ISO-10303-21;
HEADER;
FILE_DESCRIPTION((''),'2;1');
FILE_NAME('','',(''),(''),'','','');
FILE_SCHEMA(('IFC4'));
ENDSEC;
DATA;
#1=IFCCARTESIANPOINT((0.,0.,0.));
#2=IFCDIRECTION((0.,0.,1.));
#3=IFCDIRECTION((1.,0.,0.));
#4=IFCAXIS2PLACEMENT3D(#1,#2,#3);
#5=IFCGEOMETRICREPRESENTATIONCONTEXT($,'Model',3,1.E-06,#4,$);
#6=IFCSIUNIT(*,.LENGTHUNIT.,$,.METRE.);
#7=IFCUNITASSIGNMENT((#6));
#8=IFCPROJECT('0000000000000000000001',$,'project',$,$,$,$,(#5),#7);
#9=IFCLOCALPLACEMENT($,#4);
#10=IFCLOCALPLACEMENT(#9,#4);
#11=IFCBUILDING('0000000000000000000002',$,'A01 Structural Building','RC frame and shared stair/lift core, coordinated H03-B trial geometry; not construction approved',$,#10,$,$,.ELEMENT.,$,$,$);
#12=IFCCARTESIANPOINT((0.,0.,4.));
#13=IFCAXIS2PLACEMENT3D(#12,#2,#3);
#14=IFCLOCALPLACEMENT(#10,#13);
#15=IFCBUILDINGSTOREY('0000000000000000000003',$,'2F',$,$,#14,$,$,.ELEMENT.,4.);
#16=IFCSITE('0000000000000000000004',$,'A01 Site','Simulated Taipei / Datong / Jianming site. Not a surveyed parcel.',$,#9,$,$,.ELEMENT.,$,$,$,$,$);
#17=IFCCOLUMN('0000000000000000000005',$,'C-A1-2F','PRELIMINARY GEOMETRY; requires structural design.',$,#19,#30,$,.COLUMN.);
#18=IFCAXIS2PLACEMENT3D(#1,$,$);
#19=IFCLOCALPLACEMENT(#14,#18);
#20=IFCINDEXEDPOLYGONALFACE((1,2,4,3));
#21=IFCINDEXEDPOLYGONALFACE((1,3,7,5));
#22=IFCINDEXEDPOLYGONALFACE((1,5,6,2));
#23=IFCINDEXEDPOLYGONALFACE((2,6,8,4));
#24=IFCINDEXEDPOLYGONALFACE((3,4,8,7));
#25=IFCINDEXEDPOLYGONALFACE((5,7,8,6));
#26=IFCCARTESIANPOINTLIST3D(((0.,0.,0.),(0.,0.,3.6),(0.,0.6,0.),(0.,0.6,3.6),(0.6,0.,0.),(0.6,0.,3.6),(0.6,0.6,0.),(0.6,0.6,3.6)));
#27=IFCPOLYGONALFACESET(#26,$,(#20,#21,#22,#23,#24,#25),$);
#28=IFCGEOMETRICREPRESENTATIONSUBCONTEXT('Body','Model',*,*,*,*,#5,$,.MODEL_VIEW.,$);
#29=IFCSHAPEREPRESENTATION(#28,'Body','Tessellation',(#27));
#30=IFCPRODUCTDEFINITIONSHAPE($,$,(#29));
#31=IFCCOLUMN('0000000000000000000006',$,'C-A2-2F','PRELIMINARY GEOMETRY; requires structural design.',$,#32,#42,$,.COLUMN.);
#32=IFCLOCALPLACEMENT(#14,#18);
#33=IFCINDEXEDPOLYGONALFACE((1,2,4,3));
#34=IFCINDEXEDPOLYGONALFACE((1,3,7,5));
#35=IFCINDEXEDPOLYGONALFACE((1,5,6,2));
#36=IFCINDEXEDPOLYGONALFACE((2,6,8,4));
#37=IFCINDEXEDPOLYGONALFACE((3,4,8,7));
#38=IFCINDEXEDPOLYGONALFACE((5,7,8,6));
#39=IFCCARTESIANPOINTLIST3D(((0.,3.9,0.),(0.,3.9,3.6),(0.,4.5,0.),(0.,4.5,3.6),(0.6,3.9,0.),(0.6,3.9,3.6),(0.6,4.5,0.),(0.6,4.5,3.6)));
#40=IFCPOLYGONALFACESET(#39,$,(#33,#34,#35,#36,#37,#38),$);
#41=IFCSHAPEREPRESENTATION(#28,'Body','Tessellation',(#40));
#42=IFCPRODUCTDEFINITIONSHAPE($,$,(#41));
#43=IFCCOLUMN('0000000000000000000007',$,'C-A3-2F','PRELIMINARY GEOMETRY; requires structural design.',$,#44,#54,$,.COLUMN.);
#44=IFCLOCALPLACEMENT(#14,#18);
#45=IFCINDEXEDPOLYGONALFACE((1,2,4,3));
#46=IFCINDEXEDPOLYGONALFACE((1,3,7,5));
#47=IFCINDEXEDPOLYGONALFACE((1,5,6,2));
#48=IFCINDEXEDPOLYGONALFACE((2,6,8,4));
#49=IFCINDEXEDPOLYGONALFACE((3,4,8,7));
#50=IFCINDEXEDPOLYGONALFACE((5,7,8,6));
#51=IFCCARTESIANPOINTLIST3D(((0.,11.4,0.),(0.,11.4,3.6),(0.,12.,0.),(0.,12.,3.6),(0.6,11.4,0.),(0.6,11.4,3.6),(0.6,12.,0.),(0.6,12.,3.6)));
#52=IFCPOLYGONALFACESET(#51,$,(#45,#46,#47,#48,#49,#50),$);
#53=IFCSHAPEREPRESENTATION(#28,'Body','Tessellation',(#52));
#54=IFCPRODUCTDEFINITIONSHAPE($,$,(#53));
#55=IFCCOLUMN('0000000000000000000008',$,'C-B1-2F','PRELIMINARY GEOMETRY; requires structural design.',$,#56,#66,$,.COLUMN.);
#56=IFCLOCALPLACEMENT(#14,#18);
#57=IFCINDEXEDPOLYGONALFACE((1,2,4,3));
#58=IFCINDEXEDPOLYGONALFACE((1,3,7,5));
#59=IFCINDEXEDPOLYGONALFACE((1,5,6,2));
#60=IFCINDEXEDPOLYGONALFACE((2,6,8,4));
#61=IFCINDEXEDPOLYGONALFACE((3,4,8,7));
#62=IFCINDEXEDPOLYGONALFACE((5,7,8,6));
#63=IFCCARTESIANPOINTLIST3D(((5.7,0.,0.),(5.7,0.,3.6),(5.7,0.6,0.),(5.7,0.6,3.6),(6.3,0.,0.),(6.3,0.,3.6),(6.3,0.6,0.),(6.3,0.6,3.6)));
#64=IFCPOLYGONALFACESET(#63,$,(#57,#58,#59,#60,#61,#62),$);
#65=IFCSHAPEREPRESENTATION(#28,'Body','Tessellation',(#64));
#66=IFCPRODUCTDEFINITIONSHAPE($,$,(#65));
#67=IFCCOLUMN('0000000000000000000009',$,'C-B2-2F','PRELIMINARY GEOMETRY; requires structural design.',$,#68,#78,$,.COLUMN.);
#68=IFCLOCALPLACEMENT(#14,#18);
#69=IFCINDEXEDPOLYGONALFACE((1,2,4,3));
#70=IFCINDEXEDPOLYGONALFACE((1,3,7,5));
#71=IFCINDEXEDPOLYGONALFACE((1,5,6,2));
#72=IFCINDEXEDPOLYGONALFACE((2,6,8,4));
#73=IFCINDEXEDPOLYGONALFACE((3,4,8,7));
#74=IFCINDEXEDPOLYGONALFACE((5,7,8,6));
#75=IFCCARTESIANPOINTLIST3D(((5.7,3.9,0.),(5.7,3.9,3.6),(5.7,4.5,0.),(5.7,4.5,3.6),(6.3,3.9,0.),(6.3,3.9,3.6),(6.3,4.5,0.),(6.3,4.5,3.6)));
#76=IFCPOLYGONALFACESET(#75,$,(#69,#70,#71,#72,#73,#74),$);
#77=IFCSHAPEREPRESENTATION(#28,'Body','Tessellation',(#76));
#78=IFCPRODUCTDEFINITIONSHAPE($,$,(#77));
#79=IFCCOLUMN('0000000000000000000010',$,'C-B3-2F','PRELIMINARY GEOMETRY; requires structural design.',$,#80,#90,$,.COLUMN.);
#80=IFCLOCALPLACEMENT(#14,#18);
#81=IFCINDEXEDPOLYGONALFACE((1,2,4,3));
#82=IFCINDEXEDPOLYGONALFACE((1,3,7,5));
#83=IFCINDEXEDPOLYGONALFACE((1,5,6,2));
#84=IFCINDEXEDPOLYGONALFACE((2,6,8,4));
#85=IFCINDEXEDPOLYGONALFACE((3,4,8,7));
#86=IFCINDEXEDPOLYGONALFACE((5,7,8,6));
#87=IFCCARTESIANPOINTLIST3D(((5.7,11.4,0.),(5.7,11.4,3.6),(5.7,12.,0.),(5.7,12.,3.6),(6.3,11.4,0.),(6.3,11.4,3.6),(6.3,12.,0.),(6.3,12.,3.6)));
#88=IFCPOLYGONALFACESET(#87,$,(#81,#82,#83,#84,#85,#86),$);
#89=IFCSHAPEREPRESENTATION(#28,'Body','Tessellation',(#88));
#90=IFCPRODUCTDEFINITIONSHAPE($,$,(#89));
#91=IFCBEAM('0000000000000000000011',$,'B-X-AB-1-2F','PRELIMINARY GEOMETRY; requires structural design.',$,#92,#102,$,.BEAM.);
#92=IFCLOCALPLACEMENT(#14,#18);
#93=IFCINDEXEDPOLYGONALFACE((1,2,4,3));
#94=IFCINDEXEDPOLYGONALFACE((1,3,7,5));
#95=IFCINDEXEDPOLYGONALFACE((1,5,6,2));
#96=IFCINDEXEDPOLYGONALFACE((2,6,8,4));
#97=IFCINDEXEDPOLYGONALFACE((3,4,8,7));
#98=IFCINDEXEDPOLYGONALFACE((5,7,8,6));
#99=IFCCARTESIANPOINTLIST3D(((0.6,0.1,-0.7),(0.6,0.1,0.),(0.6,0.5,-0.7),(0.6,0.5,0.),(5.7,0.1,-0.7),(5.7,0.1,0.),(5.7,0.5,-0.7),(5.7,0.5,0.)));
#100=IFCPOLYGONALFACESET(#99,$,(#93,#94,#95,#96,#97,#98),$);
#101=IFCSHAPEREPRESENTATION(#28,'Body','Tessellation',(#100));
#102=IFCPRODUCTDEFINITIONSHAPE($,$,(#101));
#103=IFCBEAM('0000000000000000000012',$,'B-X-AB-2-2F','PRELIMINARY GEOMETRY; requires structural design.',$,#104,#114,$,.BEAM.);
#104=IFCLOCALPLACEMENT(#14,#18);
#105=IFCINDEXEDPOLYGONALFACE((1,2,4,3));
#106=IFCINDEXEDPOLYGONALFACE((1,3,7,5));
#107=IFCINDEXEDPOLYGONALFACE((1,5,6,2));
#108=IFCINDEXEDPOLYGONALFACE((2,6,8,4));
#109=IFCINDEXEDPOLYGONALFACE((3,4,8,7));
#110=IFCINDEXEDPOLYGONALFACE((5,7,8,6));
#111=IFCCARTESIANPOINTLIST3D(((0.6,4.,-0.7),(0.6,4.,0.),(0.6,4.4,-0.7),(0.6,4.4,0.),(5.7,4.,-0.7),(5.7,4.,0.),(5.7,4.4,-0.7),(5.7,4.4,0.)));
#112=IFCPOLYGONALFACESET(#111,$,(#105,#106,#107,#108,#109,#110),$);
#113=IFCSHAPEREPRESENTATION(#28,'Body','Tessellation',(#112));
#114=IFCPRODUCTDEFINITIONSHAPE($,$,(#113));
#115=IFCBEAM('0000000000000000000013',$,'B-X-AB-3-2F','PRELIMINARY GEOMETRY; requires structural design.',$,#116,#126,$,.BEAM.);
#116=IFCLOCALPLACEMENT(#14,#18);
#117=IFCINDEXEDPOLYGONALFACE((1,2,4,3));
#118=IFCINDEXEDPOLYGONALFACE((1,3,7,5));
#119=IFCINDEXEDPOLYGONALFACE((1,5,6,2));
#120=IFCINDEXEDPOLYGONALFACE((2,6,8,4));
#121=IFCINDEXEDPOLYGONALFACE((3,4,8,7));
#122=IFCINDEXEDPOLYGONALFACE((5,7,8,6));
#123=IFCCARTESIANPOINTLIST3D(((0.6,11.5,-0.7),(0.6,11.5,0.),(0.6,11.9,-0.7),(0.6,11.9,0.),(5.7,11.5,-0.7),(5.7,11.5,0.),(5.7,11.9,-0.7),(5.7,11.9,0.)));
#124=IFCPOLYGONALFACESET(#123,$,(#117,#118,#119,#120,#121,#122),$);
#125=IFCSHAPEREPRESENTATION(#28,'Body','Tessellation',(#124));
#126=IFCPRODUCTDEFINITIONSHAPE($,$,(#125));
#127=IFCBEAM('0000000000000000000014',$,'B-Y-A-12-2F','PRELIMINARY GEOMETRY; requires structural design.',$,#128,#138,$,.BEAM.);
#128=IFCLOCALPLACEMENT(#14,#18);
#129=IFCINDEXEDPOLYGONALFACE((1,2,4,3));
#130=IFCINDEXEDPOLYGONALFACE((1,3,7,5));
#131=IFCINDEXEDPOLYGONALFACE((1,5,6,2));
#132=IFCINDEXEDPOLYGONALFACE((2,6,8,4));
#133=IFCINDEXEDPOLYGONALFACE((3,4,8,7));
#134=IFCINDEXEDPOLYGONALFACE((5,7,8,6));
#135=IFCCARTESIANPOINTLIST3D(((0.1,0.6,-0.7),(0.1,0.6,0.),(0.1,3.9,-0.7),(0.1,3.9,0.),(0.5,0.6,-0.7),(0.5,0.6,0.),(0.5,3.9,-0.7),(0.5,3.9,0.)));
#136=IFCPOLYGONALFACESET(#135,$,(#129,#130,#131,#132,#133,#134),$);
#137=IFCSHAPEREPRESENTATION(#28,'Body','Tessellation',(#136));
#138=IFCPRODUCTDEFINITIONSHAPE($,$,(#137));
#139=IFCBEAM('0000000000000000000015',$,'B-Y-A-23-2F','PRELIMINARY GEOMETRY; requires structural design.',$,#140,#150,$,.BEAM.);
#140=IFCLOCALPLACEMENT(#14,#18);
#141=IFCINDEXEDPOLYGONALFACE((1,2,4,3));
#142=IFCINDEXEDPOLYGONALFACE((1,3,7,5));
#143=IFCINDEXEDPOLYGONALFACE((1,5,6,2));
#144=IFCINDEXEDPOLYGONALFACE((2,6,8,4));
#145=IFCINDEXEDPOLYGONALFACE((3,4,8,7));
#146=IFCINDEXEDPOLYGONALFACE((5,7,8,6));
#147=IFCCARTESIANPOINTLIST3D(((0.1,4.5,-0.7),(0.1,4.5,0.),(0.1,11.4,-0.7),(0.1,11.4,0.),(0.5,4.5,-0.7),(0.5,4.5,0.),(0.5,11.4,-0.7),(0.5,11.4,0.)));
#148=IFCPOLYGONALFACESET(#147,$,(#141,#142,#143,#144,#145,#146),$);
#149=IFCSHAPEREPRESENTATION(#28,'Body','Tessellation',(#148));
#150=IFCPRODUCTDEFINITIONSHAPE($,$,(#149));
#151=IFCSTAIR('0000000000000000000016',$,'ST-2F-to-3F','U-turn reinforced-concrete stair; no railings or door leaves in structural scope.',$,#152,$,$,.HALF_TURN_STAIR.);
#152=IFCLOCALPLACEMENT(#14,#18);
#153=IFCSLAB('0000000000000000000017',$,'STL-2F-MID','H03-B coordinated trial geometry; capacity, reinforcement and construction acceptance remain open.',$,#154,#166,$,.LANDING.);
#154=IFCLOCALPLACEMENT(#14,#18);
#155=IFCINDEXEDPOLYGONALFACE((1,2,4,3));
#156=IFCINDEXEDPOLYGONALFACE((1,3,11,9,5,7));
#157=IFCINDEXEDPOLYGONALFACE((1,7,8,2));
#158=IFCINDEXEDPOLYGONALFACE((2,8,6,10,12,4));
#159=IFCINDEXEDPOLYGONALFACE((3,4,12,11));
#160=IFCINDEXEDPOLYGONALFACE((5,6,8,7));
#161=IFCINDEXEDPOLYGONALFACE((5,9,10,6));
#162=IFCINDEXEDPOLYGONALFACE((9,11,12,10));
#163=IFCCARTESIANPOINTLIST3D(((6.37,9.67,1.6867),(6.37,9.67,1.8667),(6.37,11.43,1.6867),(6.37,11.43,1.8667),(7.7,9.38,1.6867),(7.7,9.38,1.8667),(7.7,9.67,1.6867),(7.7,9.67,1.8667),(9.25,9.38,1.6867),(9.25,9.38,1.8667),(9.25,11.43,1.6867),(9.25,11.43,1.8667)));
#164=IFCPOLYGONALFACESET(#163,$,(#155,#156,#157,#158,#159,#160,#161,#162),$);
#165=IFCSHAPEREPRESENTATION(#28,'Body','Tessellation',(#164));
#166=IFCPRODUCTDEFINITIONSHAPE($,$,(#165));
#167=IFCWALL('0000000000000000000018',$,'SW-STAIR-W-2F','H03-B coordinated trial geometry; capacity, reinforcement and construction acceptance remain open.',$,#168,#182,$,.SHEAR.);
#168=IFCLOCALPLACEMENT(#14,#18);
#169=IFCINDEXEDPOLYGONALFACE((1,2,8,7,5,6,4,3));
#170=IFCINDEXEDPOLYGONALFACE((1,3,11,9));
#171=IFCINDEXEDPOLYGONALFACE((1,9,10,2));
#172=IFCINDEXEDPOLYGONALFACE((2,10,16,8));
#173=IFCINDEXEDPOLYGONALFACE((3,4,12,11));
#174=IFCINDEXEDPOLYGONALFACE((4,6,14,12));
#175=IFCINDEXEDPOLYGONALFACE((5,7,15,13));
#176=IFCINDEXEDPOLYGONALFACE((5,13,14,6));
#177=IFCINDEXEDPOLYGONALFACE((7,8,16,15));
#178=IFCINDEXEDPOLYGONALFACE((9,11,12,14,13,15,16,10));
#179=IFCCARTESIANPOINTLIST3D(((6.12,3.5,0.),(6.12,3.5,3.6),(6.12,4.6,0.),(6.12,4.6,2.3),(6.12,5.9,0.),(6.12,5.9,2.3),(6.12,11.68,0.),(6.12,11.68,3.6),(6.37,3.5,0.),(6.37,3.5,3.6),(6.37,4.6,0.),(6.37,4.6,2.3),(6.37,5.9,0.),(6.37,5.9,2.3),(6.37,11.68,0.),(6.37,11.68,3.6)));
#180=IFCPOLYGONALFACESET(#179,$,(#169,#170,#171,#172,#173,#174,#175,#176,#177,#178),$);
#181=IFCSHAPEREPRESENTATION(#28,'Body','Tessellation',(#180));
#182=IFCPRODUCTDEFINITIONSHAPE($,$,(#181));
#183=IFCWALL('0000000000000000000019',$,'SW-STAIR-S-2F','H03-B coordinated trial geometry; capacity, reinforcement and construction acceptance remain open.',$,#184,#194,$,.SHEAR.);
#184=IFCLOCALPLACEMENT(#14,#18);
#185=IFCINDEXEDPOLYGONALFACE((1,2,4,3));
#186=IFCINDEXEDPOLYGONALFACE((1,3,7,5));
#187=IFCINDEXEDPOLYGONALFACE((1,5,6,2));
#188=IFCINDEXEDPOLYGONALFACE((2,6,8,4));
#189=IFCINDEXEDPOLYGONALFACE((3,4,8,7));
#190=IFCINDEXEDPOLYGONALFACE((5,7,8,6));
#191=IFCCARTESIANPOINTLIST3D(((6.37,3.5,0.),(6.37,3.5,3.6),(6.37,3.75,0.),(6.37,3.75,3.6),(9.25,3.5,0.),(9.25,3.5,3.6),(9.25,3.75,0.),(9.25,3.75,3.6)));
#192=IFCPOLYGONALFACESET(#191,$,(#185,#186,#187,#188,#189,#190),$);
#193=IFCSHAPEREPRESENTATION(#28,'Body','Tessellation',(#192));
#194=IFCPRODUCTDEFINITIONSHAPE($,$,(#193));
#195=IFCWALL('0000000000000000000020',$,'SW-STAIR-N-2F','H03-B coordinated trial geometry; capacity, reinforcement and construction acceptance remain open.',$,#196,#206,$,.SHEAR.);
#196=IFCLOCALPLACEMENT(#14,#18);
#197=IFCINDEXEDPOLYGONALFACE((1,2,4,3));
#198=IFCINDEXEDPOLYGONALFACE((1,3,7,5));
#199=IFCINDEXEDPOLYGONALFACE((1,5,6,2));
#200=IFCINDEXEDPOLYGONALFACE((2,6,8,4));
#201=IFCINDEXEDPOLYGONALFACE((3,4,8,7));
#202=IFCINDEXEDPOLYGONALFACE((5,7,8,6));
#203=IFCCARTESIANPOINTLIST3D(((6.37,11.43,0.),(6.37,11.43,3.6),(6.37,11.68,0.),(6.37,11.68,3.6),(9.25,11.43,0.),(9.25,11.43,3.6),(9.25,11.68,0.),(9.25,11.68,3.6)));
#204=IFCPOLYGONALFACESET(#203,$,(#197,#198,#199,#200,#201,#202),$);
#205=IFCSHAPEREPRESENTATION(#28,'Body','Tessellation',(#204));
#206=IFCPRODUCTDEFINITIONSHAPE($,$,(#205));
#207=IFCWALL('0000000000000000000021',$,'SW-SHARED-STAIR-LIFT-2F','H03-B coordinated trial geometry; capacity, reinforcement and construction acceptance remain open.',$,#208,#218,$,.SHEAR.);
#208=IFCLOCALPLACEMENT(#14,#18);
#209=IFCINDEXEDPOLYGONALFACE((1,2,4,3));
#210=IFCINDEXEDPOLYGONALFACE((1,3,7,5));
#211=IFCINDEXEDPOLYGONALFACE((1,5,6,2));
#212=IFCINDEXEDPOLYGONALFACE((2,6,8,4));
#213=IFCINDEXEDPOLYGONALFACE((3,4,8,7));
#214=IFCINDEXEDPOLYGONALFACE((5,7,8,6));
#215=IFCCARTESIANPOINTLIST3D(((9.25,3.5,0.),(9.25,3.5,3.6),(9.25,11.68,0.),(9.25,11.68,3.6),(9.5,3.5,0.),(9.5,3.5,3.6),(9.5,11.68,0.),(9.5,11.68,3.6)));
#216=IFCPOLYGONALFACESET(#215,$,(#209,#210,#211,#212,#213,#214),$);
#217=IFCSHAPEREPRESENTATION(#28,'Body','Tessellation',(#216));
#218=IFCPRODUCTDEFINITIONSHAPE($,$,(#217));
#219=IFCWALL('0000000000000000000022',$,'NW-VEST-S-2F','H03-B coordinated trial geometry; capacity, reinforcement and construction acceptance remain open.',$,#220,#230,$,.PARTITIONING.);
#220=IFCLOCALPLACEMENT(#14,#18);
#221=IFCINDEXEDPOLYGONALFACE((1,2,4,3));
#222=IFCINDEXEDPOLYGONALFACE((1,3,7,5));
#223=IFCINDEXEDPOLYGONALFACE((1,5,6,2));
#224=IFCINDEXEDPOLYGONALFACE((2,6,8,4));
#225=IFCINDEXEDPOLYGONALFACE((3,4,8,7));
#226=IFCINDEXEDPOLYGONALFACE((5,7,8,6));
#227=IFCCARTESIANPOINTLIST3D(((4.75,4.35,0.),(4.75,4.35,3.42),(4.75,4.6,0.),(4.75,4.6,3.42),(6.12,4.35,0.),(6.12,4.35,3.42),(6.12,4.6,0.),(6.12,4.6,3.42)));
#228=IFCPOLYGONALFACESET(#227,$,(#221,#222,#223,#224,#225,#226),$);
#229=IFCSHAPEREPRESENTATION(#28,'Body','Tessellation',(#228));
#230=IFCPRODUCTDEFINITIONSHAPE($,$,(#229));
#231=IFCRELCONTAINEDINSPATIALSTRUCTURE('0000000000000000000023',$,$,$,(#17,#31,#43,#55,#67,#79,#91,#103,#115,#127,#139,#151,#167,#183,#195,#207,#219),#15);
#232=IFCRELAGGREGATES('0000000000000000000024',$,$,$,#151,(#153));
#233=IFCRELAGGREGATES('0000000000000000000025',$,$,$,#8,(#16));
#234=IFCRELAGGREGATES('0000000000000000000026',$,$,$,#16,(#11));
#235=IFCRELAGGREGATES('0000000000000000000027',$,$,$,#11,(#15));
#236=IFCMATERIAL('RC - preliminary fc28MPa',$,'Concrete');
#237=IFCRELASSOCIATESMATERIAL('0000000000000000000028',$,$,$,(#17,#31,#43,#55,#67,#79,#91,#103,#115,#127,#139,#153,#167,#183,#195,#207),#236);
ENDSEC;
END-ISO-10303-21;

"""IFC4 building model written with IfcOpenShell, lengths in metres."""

from ifc_helpers import new_model, si_unit, frame, origin_with_axes, place, context, subcontext, project, spatial, polyline, rectangle, outline, extrude, material, element, aggregate, save


model = new_model("IFC4")

# Units and contexts
model_context = context("Model", 3, precision=1e-06, world=origin_with_axes())
body_context = subcontext(model_context, "Body", "Model", "MODEL_VIEW")
ifc_project = project(units=[si_unit("LENGTHUNIT", "METRE")], contexts=[model_context])

# Site, building, storey
site_placement = place(None, origin_with_axes())
site = spatial("IfcSite", under=ifc_project, at=site_placement, Name="A01 Site", Description="Simulated Taipei / Datong / Jianming site. Not a surveyed parcel.", CompositionType="ELEMENT")
building_placement = place(site_placement, origin_with_axes())
building = spatial("IfcBuilding", under=site, at=building_placement, Name="A01 Structural Building", Description="RC frame and shared stair/lift core, coordinated H03-B trial geometry; not construction approved", CompositionType="ELEMENT")
storey_placement = place(building_placement, frame((0.0, 0.0, 4.0), z_axis=(0.0, 0.0, 1.0), x_axis=(1.0, 0.0, 0.0)))
storey = spatial("IfcBuildingStorey", under=building, at=storey_placement, Name="2F", CompositionType="ELEMENT", Elevation=4.0)

# Columns
ifc_material = material(Name="RC - preliminary fc28MPa", Category="Concrete")
for number, where, z_axis, x_axis, name in (
    (1, (0.3, 0.3, 0.0), (0.0, 0.0, 1.0), (1.0, 0.0, 0.0), "C-A1-2F"),
    (2, (0.3, 4.2, 0.0), (0.0, 0.0, 1.0), (1.0, 0.0, 0.0), "C-A2-2F"),
    (3, (0.3, 11.7, 0.0), (0.0, 0.0, 1.0), (1.0, 0.0, 0.0), "C-A3-2F"),
    (4, (6.0, 0.3, 0.0), (0.0, 0.0, 1.0), (1.0, 0.0, 0.0), "C-B1-2F"),
    (5, (6.0, 4.2, 0.0), (0.0, 0.0, 1.0), (1.0, 0.0, 0.0), "C-B2-2F"),
    (6, (6.0, 11.7, 0.0), (0.0, 0.0, 1.0), (1.0, 0.0, 0.0), "C-B3-2F"),
):
    element("IfcColumn", number, at=place(storey_placement, frame(where, z_axis=z_axis, x_axis=x_axis)), inside=storey, material=ifc_material, Name=name, Description="PRELIMINARY GEOMETRY; requires structural design.", PredefinedType="COLUMN", context=body_context, shape_type="SweptSolid", body=[
        extrude(rectangle(XDim=0.6, YDim=0.6), origin_with_axes(), (0.0, 0.0, 1.0), 3.6),
    ])

# Beams
for number, where, z_axis, x_axis, name in (
    (7, (3.15, 0.3, -0.7), (0.0, 0.0, 1.0), (1.0, 0.0, 0.0), "B-X-AB-1-2F"),
    (8, (3.15, 4.2, -0.7), (0.0, 0.0, 1.0), (1.0, 0.0, 0.0), "B-X-AB-2-2F"),
    (9, (3.15, 11.7, -0.7), (0.0, 0.0, 1.0), (1.0, 0.0, 0.0), "B-X-AB-3-2F"),
):
    element("IfcBeam", number, at=place(storey_placement, frame(where, z_axis=z_axis, x_axis=x_axis)), inside=storey, material=ifc_material, Name=name, Description="PRELIMINARY GEOMETRY; requires structural design.", PredefinedType="BEAM", context=body_context, shape_type="SweptSolid", body=[
        extrude(rectangle(XDim=5.1, YDim=0.4), origin_with_axes(), (0.0, 0.0, 1.0), 0.7),
    ])
beam_1_placement = place(storey_placement, frame((0.3, 2.25, -0.7), z_axis=(0.0, 0.0, 1.0), x_axis=(1.0, 0.0, 0.0)))
element("IfcBeam", 10, at=beam_1_placement, inside=storey, material=ifc_material, Name="B-Y-A-12-2F", Description="PRELIMINARY GEOMETRY; requires structural design.", PredefinedType="BEAM", context=body_context, shape_type="SweptSolid", body=[
    extrude(rectangle(XDim=0.4, YDim=3.3), origin_with_axes(), (0.0, 0.0, 1.0), 0.7),
])
beam_2_placement = place(storey_placement, frame((0.3, 7.95, -0.7), z_axis=(0.0, 0.0, 1.0), x_axis=(1.0, 0.0, 0.0)))
element("IfcBeam", 11, at=beam_2_placement, inside=storey, material=ifc_material, Name="B-Y-A-23-2F", Description="PRELIMINARY GEOMETRY; requires structural design.", PredefinedType="BEAM", context=body_context, shape_type="SweptSolid", body=[
    extrude(rectangle(XDim=0.4, YDim=6.9), origin_with_axes(), (0.0, 0.0, 1.0), 0.7),
])

# Stair, slab
stair_placement = place(storey_placement, origin_with_axes())
stair = element("IfcStair", 12, at=stair_placement, inside=storey, Name="ST-2F-to-3F", Description="U-turn reinforced-concrete stair; no railings or door leaves in structural scope.", PredefinedType="HALF_TURN_STAIR")
placement = place(None, origin_with_axes())
slab = element("IfcSlab", 13, at=placement, material=ifc_material, Name="STL-2F-MID", Description="H03-B coordinated trial geometry; capacity, reinforcement and construction acceptance remain open.", PredefinedType="LANDING", context=body_context, shape_type="SweptSolid", body=[
    extrude(outline(polyline([(6.37, 9.67), (7.7, 9.67), (7.7, 9.38), (9.25, 9.38), (9.25, 11.43), (6.37, 11.43), (6.37, 9.67)])), frame((0.0, 0.0, 5.6867), z_axis=(0.0, 0.0, 1.0), x_axis=(1.0, 0.0, 0.0)), (0.0, 0.0, 1.0), 0.18),
])

# Wall, opening
wall_1 = element("IfcWall", 14, at=placement, inside=storey, material=ifc_material, Name="SW-STAIR-W-2F", Description="H03-B coordinated trial geometry; capacity, reinforcement and construction acceptance remain open.", PredefinedType="SHEAR", context=body_context, shape_type="SweptSolid", body=[
    extrude(outline(polyline([(6.37, 3.5), (6.37, 11.68), (6.12, 11.68), (6.12, 3.5), (6.37, 3.5)])), frame((0.0, 0.0, 4.0), z_axis=(0.0, 0.0, 1.0), x_axis=(1.0, 0.0, 0.0)), (0.0, 0.0, 1.0), 3.6),
])
element("IfcOpeningElement", 15, at=placement, cuts=wall_1, PredefinedType="OPENING", context=body_context, shape_type="SweptSolid", body=[
    extrude(outline(polyline([(6.42, 4.6), (6.42, 5.9), (6.07, 5.9), (6.07, 4.6), (6.42, 4.6)])), frame((0.0, 0.0, 4.0), z_axis=(0.0, 0.0, 1.0), x_axis=(1.0, 0.0, 0.0)), (0.0, 0.0, 1.0), 2.3),
])

# Walls
element("IfcWall", 16, at=placement, inside=storey, material=ifc_material, Name="SW-STAIR-S-2F", Description="H03-B coordinated trial geometry; capacity, reinforcement and construction acceptance remain open.", PredefinedType="SHEAR", context=body_context, shape_type="SweptSolid", body=[
    extrude(outline(polyline([(9.25, 3.5), (9.25, 3.75), (6.37, 3.75), (6.37, 3.5), (9.25, 3.5)])), frame((0.0, 0.0, 4.0), z_axis=(0.0, 0.0, 1.0), x_axis=(1.0, 0.0, 0.0)), (0.0, 0.0, 1.0), 3.6),
])
element("IfcWall", 17, at=placement, inside=storey, material=ifc_material, Name="SW-STAIR-N-2F", Description="H03-B coordinated trial geometry; capacity, reinforcement and construction acceptance remain open.", PredefinedType="SHEAR", context=body_context, shape_type="SweptSolid", body=[
    extrude(outline(polyline([(9.25, 11.43), (9.25, 11.68), (6.37, 11.68), (6.37, 11.43), (9.25, 11.43)])), frame((0.0, 0.0, 4.0), z_axis=(0.0, 0.0, 1.0), x_axis=(1.0, 0.0, 0.0)), (0.0, 0.0, 1.0), 3.6),
])
element("IfcWall", 18, at=placement, inside=storey, material=ifc_material, Name="SW-SHARED-STAIR-LIFT-2F", Description="H03-B coordinated trial geometry; capacity, reinforcement and construction acceptance remain open.", PredefinedType="SHEAR", context=body_context, shape_type="SweptSolid", body=[
    extrude(outline(polyline([(9.5, 3.5), (9.5, 11.68), (9.25, 11.68), (9.25, 3.5), (9.5, 3.5)])), frame((0.0, 0.0, 4.0), z_axis=(0.0, 0.0, 1.0), x_axis=(1.0, 0.0, 0.0)), (0.0, 0.0, 1.0), 3.6),
])

# Wall
element("IfcWall", 19, at=placement, inside=storey, Name="NW-VEST-S-2F", Description="H03-B coordinated trial geometry; capacity, reinforcement and construction acceptance remain open.", PredefinedType="PARTITIONING", context=body_context, shape_type="SweptSolid", body=[
    extrude(outline(polyline([(6.12, 4.35), (6.12, 4.6), (4.75, 4.6), (4.75, 4.35), (6.12, 4.35)])), frame((0.0, 0.0, 4.0), z_axis=(0.0, 0.0, 1.0), x_axis=(1.0, 0.0, 0.0)), (0.0, 0.0, 1.0), 3.42),
])

aggregate(stair, [slab])

save(model, "model.ifc")
